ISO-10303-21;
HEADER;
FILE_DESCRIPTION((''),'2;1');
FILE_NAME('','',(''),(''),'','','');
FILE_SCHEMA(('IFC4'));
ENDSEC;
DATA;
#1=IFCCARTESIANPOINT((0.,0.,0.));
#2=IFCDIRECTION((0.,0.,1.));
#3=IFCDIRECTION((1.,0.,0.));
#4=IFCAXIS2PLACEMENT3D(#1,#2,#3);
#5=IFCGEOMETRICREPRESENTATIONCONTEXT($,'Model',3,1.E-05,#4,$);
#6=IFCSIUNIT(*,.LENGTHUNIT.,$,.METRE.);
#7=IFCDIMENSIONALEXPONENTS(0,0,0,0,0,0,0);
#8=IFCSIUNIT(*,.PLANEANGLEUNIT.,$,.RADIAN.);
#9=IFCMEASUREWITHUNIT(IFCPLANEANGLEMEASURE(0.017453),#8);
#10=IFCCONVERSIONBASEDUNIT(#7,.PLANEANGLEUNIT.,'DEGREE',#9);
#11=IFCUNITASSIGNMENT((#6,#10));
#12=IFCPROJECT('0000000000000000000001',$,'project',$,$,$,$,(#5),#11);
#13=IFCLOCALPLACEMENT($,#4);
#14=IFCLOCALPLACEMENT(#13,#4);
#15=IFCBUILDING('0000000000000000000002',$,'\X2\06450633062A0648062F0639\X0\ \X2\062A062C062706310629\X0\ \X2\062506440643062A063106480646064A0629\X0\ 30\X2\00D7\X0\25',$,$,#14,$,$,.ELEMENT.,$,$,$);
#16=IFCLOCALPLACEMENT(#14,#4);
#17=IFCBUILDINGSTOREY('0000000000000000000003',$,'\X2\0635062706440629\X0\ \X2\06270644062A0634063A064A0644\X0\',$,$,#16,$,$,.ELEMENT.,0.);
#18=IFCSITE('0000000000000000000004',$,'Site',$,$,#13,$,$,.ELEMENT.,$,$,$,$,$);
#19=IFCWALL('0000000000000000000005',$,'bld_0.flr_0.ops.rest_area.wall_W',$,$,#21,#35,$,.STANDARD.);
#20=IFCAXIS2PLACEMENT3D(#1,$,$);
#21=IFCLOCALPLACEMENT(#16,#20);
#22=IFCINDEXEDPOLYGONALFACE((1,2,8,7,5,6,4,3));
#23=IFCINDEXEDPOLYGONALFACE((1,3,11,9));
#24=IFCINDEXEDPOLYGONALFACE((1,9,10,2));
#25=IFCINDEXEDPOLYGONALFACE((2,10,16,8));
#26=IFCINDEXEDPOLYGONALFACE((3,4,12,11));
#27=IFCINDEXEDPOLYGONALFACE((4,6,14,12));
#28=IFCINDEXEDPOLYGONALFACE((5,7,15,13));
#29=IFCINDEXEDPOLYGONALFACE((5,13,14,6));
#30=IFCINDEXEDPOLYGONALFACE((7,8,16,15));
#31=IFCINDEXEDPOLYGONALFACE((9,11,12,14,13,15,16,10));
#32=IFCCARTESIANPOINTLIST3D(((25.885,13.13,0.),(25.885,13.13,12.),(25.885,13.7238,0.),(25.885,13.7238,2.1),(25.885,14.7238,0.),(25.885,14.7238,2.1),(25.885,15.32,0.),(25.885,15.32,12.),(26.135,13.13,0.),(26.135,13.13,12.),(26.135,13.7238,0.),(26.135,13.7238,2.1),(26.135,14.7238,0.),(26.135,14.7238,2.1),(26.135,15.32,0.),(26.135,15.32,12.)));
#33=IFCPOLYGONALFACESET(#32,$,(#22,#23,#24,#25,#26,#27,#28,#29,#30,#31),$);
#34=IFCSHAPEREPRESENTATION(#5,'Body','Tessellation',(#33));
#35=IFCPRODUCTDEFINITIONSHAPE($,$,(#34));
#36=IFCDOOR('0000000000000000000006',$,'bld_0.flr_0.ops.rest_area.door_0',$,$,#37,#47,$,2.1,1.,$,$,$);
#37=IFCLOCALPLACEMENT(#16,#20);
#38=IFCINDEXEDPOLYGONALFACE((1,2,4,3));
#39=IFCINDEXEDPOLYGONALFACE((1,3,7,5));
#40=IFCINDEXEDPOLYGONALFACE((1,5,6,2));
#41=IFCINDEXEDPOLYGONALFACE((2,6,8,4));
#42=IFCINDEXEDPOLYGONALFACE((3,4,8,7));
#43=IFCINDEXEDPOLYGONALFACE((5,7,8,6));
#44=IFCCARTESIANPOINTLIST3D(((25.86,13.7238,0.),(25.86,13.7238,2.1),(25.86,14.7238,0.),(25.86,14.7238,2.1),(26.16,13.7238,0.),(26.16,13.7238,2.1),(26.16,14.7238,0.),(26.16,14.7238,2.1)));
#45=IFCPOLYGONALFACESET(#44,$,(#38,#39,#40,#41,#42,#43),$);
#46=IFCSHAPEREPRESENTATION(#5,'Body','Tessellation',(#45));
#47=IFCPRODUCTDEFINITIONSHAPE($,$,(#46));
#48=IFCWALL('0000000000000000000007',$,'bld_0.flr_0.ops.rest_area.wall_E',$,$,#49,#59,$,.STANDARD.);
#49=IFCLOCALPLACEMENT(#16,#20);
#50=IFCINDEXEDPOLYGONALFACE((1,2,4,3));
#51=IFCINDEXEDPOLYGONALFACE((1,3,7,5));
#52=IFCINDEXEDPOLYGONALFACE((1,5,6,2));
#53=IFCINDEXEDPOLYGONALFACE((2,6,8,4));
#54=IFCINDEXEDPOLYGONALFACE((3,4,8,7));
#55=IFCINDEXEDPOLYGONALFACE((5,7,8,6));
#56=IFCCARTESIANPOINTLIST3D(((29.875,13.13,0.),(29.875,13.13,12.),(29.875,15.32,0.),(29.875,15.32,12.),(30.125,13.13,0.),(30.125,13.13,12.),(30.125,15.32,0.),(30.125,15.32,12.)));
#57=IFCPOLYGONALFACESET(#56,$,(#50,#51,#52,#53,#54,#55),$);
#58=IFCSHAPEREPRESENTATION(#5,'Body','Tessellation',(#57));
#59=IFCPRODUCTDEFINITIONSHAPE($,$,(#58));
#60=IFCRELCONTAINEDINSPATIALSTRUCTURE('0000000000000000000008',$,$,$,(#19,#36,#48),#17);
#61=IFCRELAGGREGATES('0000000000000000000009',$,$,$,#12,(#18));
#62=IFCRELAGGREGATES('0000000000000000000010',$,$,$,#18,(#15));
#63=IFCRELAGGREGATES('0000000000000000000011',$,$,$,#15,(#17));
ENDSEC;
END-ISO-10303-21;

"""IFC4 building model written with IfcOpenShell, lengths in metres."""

from ifc_helpers import new_model, entity, si_unit, converted_unit, frame, frame_2d, origin_with_axes, origin_2d_with_axis, place, context, project, spatial, rectangle, extrude, element, fill, save


model = new_model("IFC4")

# Units and contexts
model_context = context("Model", 3, precision=1e-05, world=origin_with_axes())
ifc_project = project(units=[si_unit("LENGTHUNIT", "METRE"), converted_unit("PLANEANGLEUNIT", "DEGREE", entity("IfcPlaneAngleMeasure", 0.017453), si_unit("PLANEANGLEUNIT", "RADIAN"), dimensions=[0, 0, 0, 0, 0, 0, 0])], contexts=[model_context])

# Site, building, storey
site_placement = place(None, origin_with_axes())
site = spatial("IfcSite", under=ifc_project, at=site_placement, Name="Site", CompositionType="ELEMENT")
building_placement = place(site_placement, origin_with_axes())
building = spatial("IfcBuilding", under=site, at=building_placement, Name="مستودع تجارة إلكترونية 30×25", CompositionType="ELEMENT")
storey_placement = place(building_placement, origin_with_axes())
storey = spatial("IfcBuildingStorey", under=building, at=storey_placement, Name="صالة التشغيل", CompositionType="ELEMENT", Elevation=0.0)

# Wall, opening, door
wall_1_placement = place(storey_placement, frame((26.01, 13.13, 0.0), z_axis=(0.0, 0.0, 1.0), x_axis=(0.0, 1.0, 0.0)))
wall_1 = element("IfcWall", 1, at=wall_1_placement, inside=storey, Name="bld_0.flr_0.ops.rest_area.wall_W", PredefinedType="STANDARD", context=model_context, shape_type="SweptSolid", body=[
    extrude(rectangle(XDim=2.19, YDim=0.25, at=frame_2d((1.095, 0.0), x_axis=(1.0, 0.0))), origin_with_axes(), (0.0, 0.0, 1.0), 12.0),
])
opening_1_placement = place(storey_placement, frame((26.01, 14.2238, 0.0), z_axis=(0.0, 0.0, 1.0), x_axis=(0.0, 1.0, 0.0)))
opening_1 = element("IfcOpeningElement", 2, at=opening_1_placement, cuts=wall_1, PredefinedType="OPENING", context=model_context, shape_type="SweptSolid", body=[
    extrude(rectangle(XDim=1.0, YDim=0.3, at=origin_2d_with_axis()), origin_with_axes(), (0.0, 0.0, 1.0), 2.1),
])
door_1_placement = place(storey_placement, frame((26.01, 14.2238, 0.0), z_axis=(0.0, 0.0, 1.0), x_axis=(0.0, 1.0, 0.0)))
door_1 = element("IfcDoor", 3, at=door_1_placement, inside=storey, Name="bld_0.flr_0.ops.rest_area.door_0", OverallHeight=2.1, OverallWidth=1.0, context=model_context, shape_type="SweptSolid", body=[
    extrude(rectangle(XDim=1.0, YDim=0.3, at=origin_2d_with_axis()), origin_with_axes(), (0.0, 0.0, 1.0), 2.1),
])
fill(opening_1, door_1)

# Wall
wall_2_placement = place(storey_placement, frame((30.0, 13.13, 0.0), z_axis=(0.0, 0.0, 1.0), x_axis=(0.0, 1.0, 0.0)))
element("IfcWall", 4, at=wall_2_placement, inside=storey, Name="bld_0.flr_0.ops.rest_area.wall_E", PredefinedType="STANDARD", context=model_context, shape_type="SweptSolid", body=[
    extrude(rectangle(XDim=2.19, YDim=0.25, at=frame_2d((1.095, 0.0), x_axis=(1.0, 0.0))), origin_with_axes(), (0.0, 0.0, 1.0), 12.0),
])

save(model, "model.ifc")
